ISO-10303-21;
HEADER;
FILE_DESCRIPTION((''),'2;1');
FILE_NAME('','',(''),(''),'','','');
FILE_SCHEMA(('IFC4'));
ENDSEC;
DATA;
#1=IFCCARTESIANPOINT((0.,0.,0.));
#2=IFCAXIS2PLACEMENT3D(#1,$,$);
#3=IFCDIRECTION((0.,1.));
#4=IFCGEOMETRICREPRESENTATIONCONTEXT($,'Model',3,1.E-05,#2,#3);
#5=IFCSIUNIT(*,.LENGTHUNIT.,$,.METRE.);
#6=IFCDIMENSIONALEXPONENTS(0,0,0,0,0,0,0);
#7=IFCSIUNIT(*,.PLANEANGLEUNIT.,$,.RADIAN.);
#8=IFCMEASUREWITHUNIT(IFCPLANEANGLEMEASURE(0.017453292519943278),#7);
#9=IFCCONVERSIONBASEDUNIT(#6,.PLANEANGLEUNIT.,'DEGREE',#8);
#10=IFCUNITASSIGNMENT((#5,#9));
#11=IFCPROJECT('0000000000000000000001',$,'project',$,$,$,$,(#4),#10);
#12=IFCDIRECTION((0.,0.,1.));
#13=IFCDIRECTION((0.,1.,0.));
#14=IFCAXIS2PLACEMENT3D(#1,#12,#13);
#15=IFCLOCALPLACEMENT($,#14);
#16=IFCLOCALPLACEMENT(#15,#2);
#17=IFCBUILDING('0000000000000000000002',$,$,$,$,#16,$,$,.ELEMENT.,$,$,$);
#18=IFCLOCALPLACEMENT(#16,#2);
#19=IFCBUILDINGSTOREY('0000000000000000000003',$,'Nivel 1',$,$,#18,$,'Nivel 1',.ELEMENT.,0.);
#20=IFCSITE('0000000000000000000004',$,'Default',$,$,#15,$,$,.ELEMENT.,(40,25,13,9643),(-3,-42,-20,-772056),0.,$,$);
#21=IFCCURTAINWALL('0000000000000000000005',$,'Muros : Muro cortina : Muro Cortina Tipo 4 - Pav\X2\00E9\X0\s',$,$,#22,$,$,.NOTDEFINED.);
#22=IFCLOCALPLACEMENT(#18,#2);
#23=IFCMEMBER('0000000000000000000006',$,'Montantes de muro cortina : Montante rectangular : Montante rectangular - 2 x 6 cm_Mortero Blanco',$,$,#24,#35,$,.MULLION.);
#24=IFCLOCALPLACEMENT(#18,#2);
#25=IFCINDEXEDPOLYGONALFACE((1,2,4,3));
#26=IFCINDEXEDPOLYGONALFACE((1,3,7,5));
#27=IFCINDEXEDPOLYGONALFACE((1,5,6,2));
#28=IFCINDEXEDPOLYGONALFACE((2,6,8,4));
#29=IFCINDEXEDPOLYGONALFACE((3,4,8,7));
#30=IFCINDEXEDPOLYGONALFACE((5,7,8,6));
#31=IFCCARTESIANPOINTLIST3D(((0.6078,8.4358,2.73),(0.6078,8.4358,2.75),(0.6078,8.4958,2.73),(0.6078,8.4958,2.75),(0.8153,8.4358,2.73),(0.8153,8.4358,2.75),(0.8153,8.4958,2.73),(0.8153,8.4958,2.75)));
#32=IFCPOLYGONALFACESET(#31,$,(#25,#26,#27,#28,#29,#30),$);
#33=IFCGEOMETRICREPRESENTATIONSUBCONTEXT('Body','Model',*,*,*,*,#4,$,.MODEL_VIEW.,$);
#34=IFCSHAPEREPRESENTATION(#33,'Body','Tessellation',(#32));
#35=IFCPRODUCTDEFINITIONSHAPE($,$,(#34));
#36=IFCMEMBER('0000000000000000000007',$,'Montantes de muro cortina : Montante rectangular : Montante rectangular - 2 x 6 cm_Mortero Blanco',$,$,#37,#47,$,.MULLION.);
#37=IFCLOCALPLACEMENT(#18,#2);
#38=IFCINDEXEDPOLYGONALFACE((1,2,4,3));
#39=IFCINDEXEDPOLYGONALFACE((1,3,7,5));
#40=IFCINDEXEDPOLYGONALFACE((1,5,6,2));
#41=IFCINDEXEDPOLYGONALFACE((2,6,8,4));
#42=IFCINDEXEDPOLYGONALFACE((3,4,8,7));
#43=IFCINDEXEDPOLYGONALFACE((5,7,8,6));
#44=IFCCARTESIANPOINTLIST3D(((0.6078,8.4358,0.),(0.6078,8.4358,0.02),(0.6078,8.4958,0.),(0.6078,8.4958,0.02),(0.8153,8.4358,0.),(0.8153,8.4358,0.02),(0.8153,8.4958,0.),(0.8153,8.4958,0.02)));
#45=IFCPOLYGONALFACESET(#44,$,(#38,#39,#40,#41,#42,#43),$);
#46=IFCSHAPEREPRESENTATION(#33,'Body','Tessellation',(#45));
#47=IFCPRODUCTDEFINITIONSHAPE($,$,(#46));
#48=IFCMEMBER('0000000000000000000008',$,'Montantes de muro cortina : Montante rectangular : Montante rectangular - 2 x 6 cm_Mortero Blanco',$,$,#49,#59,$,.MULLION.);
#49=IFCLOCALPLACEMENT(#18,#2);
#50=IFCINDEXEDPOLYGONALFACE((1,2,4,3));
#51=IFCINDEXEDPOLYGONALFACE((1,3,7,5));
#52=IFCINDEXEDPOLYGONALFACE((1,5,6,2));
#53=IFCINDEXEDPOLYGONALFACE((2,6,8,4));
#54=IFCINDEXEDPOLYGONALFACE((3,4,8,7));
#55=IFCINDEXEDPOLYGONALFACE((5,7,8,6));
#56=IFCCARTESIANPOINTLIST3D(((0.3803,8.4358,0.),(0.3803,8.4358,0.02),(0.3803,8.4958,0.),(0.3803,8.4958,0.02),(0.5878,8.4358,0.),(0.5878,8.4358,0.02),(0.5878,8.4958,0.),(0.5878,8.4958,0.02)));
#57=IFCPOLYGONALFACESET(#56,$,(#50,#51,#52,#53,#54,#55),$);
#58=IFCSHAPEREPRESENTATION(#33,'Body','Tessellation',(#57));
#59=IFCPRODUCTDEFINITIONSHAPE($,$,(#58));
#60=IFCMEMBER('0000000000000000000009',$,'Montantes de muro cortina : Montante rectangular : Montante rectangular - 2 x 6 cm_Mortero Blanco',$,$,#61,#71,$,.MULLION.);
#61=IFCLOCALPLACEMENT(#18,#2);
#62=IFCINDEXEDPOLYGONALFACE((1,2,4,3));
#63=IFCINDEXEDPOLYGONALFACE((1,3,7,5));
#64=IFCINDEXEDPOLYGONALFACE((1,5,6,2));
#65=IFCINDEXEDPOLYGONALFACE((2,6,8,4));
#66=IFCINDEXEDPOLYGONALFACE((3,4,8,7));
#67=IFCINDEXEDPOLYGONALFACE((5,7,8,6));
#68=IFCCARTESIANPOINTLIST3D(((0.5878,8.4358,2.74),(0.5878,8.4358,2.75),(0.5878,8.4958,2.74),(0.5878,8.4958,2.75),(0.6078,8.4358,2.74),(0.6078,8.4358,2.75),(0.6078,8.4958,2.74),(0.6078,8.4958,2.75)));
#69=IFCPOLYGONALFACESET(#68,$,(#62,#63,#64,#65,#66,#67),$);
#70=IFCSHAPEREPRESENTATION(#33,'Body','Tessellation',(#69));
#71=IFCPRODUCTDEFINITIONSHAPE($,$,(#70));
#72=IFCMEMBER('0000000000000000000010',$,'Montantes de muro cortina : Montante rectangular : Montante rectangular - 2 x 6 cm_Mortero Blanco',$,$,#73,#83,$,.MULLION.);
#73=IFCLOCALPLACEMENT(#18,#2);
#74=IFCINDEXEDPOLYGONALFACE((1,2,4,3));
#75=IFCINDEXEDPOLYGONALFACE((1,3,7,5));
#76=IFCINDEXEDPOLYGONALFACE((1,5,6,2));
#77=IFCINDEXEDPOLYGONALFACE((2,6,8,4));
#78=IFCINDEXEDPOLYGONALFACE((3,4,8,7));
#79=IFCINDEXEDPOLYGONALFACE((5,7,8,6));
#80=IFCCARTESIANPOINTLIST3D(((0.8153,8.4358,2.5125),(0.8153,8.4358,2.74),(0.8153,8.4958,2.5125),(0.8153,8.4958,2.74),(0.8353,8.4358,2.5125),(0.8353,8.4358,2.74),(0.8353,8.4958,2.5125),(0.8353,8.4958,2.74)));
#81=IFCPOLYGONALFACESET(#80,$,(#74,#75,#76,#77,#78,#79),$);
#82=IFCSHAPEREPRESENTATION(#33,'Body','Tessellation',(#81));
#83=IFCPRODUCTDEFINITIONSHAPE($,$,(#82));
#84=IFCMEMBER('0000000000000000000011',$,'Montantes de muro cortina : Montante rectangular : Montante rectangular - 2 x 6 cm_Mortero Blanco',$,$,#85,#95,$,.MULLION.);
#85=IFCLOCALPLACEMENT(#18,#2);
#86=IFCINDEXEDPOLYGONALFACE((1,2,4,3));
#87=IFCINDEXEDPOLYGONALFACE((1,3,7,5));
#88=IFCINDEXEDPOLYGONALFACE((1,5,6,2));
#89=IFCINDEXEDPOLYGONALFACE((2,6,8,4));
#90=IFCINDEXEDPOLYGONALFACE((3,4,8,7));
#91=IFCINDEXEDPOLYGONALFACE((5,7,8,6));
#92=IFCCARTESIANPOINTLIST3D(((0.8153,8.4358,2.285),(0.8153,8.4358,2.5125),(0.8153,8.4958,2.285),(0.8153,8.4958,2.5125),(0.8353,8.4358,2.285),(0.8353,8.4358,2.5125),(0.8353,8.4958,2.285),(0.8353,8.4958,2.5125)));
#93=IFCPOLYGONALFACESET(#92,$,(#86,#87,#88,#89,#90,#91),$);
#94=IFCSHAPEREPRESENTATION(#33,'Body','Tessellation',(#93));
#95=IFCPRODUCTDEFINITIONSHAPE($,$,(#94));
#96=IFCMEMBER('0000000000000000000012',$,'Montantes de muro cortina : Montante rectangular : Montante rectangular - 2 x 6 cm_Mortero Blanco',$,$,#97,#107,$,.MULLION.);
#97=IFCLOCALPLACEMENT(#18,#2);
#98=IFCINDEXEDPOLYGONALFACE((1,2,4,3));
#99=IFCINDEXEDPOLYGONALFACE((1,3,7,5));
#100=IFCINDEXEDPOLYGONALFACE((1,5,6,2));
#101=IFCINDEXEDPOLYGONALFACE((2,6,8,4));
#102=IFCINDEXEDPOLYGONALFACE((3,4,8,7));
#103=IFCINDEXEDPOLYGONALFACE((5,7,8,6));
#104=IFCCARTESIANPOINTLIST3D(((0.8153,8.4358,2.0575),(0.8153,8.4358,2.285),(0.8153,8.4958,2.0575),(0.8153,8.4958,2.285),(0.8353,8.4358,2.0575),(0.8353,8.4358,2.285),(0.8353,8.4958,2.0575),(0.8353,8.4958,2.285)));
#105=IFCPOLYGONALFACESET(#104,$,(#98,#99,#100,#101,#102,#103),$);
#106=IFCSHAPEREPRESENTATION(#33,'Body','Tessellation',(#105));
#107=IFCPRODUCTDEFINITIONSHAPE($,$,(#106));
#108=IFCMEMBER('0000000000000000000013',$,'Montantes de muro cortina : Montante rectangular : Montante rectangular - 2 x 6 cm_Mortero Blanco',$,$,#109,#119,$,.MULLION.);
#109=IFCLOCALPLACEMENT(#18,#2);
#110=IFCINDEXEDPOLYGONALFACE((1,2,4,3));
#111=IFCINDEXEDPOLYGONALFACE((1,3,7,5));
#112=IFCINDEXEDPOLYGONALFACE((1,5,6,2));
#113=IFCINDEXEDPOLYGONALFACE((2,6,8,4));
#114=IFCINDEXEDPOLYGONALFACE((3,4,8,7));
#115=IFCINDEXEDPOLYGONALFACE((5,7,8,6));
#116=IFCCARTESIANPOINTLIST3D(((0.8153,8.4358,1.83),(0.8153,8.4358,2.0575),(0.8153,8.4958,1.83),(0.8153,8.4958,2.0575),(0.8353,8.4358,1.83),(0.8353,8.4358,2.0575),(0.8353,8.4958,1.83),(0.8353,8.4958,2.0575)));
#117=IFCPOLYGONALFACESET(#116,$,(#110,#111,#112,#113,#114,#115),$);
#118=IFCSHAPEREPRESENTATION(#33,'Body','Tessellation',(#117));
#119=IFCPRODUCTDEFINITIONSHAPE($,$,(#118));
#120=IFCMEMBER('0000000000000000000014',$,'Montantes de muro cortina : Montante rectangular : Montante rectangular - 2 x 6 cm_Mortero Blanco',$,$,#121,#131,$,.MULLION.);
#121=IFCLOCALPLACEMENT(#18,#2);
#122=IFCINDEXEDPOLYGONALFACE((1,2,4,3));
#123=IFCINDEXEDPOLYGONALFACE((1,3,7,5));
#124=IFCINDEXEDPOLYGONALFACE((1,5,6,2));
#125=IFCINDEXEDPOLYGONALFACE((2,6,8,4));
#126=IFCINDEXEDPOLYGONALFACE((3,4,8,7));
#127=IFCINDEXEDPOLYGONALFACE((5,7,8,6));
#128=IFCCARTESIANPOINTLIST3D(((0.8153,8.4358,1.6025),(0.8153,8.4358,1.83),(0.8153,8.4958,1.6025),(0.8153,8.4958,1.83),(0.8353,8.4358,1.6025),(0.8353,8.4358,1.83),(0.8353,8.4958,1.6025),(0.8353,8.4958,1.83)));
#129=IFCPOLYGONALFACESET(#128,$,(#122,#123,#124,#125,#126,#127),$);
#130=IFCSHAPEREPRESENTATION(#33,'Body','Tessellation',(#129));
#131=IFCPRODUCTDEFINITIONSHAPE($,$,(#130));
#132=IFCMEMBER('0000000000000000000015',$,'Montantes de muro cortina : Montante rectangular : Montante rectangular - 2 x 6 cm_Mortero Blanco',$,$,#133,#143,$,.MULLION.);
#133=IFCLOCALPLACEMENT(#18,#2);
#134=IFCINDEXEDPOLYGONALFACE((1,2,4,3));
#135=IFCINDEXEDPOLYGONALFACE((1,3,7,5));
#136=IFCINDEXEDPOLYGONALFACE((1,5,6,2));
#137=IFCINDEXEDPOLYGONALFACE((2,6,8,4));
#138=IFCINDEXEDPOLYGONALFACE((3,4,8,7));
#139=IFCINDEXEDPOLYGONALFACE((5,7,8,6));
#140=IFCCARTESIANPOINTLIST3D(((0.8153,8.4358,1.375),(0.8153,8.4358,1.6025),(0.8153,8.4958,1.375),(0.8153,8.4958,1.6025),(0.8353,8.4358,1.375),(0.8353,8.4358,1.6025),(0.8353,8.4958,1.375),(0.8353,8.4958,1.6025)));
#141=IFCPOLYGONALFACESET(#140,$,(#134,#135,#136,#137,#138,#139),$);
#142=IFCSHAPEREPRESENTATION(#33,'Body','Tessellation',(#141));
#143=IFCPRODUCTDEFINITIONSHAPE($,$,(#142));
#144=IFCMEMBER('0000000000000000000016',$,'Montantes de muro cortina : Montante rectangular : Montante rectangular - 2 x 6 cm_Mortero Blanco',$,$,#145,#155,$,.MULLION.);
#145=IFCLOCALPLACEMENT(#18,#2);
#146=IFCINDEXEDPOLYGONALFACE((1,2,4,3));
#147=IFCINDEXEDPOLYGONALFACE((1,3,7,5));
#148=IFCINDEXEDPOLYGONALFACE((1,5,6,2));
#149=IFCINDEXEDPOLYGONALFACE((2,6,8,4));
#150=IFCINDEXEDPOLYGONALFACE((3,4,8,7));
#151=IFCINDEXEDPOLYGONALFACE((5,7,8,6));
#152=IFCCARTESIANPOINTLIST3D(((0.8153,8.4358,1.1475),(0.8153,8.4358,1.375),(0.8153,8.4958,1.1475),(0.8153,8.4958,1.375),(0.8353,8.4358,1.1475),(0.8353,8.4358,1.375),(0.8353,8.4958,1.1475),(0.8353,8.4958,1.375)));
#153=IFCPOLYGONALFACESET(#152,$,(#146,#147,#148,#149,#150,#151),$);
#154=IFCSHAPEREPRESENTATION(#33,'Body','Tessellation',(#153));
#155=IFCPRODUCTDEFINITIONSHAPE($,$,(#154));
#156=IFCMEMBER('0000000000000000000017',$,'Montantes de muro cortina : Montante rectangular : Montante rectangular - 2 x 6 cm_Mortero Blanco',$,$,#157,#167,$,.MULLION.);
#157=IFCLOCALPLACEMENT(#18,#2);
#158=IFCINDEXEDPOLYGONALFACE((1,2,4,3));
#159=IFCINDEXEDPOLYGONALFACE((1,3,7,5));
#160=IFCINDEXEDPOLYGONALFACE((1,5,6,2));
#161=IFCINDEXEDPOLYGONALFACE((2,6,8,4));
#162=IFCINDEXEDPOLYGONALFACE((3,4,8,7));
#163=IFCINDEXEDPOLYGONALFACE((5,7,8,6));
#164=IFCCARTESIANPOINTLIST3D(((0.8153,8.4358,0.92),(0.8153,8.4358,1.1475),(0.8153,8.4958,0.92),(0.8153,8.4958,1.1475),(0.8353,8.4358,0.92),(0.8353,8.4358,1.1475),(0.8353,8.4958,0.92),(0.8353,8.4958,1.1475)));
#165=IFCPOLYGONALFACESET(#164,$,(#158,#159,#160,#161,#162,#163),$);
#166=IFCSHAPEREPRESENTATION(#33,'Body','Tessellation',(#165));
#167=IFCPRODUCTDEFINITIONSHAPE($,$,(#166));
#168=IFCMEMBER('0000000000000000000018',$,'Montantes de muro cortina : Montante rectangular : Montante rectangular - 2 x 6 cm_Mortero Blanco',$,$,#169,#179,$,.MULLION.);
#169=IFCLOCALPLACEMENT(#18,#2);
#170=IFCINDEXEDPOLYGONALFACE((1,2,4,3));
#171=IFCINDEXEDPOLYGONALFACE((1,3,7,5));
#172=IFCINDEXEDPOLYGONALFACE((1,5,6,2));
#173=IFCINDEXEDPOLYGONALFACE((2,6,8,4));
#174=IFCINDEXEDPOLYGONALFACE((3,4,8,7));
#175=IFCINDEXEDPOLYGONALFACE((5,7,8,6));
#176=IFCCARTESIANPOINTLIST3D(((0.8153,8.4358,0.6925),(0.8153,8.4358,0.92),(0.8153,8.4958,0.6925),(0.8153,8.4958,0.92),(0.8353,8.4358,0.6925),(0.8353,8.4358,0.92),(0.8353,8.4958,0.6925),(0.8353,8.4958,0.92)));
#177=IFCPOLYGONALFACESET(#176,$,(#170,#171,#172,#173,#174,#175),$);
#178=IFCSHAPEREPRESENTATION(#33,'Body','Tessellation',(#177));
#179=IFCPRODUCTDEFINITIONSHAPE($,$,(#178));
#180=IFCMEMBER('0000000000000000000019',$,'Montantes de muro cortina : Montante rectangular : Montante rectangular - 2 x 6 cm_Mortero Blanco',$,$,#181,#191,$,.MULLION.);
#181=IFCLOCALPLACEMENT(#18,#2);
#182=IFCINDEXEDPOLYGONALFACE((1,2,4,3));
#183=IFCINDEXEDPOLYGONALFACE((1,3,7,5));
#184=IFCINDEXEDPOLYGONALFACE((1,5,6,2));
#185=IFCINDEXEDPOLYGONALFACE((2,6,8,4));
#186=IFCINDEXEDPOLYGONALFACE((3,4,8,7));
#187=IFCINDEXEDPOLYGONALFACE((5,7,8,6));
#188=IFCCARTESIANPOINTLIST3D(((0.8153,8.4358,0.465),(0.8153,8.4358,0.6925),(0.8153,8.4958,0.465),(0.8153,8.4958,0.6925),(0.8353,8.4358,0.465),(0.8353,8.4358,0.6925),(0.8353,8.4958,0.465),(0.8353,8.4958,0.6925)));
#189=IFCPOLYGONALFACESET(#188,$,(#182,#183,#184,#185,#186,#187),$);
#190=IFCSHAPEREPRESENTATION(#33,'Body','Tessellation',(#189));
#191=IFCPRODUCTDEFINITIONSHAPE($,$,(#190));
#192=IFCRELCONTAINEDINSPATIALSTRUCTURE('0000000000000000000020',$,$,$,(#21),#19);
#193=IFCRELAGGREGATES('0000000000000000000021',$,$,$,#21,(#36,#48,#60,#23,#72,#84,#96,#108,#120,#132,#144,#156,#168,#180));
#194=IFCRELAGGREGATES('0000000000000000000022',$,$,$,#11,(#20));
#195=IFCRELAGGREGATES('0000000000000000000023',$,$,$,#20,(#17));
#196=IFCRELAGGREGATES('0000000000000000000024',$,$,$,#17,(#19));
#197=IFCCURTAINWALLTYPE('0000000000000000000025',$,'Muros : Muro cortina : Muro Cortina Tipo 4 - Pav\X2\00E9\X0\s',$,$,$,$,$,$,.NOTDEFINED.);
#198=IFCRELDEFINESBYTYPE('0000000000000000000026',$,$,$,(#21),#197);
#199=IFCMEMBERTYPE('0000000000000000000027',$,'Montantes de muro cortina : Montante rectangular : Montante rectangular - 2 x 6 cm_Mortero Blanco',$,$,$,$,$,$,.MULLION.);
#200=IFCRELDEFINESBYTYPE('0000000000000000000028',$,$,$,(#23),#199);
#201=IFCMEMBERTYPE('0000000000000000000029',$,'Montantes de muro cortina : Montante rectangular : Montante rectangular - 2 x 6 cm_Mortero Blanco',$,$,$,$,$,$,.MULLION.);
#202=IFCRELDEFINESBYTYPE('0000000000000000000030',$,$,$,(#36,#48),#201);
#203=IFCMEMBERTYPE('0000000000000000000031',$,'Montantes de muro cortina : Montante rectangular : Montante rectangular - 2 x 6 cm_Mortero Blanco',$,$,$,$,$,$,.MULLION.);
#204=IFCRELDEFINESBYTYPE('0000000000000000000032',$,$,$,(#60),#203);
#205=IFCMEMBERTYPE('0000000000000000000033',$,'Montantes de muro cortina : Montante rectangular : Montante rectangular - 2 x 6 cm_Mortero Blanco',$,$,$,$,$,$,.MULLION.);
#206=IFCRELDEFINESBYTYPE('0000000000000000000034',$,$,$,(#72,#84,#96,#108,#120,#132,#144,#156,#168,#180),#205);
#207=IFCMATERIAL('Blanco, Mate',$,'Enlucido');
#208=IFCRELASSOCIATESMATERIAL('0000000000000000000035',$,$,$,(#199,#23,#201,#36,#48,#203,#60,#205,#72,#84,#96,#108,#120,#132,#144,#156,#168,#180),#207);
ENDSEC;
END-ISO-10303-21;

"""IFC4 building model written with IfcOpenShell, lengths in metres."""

from ifc_helpers import new_model, entity, si_unit, converted_unit, direction, frame, origin, place, context, subcontext, project, spatial, indexed_curve, outline, extrude, source, transform, mapped, material, type_object, type_shapes, element, aggregate, save


model = new_model("IFC4")

# Units and contexts
model_context = context("Model", 3, precision=1e-05, world=origin(), true_north=direction((0.0, 1.0)))
body_context = subcontext(model_context, "Body", "Model", "MODEL_VIEW")
ifc_project = project(units=[si_unit("LENGTHUNIT", "METRE"), converted_unit("PLANEANGLEUNIT", "DEGREE", entity("IfcPlaneAngleMeasure", 0.017453292519943278), si_unit("PLANEANGLEUNIT", "RADIAN"), dimensions=[0, 0, 0, 0, 0, 0, 0])], contexts=[model_context])

# Site, building, storey
site_placement = place(None, frame((0.0, 0.0, 0.0), z_axis=(0.0, 0.0, 1.0), x_axis=(0.0, 1.0, 0.0)))
site = spatial("IfcSite", under=ifc_project, at=site_placement, Name="Default", CompositionType="ELEMENT", RefLatitude=(40, 25, 13, 9643), RefLongitude=(-3, -42, -20, -772056), RefElevation=0.0)
building_placement = place(site_placement, origin())
building = spatial("IfcBuilding", under=site, at=building_placement, CompositionType="ELEMENT")
storey_placement = place(building_placement, origin())
storey = spatial("IfcBuildingStorey", under=building, at=storey_placement, Name="Nivel 1", LongName="Nivel 1", CompositionType="ELEMENT", Elevation=0.0)

# Curtain wall, members
curtain_wall_type_1 = type_object("IfcCurtainWallType", Name="Muros : Muro cortina : Muro Cortina Tipo 4 - Pavés", PredefinedType="NOTDEFINED")
curtain_wall_1_placement = place(storey_placement, origin())
curtain_wall_1 = element("IfcCurtainWall", 1, at=curtain_wall_1_placement, inside=storey, type_object=curtain_wall_type_1, Name="Muros : Muro cortina : Muro Cortina Tipo 4 - Pavés", PredefinedType="NOTDEFINED")
ifc_material_1 = material(Name="Blanco, Mate", Category="Enlucido")
member_type_1 = type_object("IfcMemberType", Name="Montantes de muro cortina : Montante rectangular : Montante rectangular - 2 x 6 cm_Mortero Blanco", PredefinedType="MULLION", material=ifc_material_1)
shared_shape_1 = source(origin(), body_context, "Body", "SweptSolid", [
    extrude(outline(indexed_curve([(-0.01, -0.03), (0.01, -0.03), (0.01, 0.03), (-0.01, 0.03), (-0.01, -0.03)], self_intersect=False)), frame((0.0, 0.0, -0.2075), z_axis=(0.0, 0.0, 1.0), x_axis=(-1.0, 0.0, 0.0)), (0.0, 0.0, 1.0), 0.2075),
])
type_shapes(member_type_1, [shared_shape_1])
member_1_placement = place(curtain_wall_1_placement, frame((0.6078, 8.4658, 2.74), z_axis=(-1.0, 0.0, 0.0), x_axis=(0.0, 0.0, 1.0)))
member_1 = element("IfcMember", 2, at=member_1_placement, type_object=member_type_1, material=ifc_material_1, Name="Montantes de muro cortina : Montante rectangular : Montante rectangular - 2 x 6 cm_Mortero Blanco", PredefinedType="MULLION", context=body_context, shape_type="MappedRepresentation", body=[
    mapped(shared_shape_1, transform((0.0, 0.0, 0.0), scale=1.0)),
])
member_type_2 = type_object("IfcMemberType", Name="Montantes de muro cortina : Montante rectangular : Montante rectangular - 2 x 6 cm_Mortero Blanco", PredefinedType="MULLION", material=ifc_material_1)
shared_shape_2 = source(origin(), body_context, "Body", "SweptSolid", [
    extrude(outline(indexed_curve([(-0.01, -0.03), (0.01, -0.03), (0.01, 0.03), (-0.01, 0.03), (-0.01, -0.03)], self_intersect=False)), frame((-0.01, 0.0, -0.2075), z_axis=(0.0, 0.0, 1.0), x_axis=(-1.0, 0.0, 0.0)), (0.0, 0.0, 1.0), 0.2075),
])
type_shapes(member_type_2, [shared_shape_2])
member_2_placement = place(curtain_wall_1_placement, frame((0.8153, 8.4658, 0.0), z_axis=(1.0, 0.0, 0.0), x_axis=(0.0, 0.0, -1.0)))
member_2 = element("IfcMember", 3, at=member_2_placement, type_object=member_type_2, material=ifc_material_1, Name="Montantes de muro cortina : Montante rectangular : Montante rectangular - 2 x 6 cm_Mortero Blanco", PredefinedType="MULLION", context=body_context, shape_type="MappedRepresentation", body=[
    mapped(shared_shape_2, transform((0.0, 0.0, 0.0), scale=1.0)),
])
member_3_placement = place(curtain_wall_1_placement, frame((0.5878, 8.4658, 0.0), z_axis=(1.0, 0.0, 0.0), x_axis=(0.0, 0.0, -1.0)))
member_3 = element("IfcMember", 4, at=member_3_placement, type_object=member_type_2, material=ifc_material_1, Name="Montantes de muro cortina : Montante rectangular : Montante rectangular - 2 x 6 cm_Mortero Blanco", PredefinedType="MULLION", context=body_context, shape_type="MappedRepresentation", body=[
    mapped(shared_shape_2, transform((0.0, 0.0, 0.0), scale=1.0)),
])
member_type_3 = type_object("IfcMemberType", Name="Montantes de muro cortina : Montante rectangular : Montante rectangular - 2 x 6 cm_Mortero Blanco", PredefinedType="MULLION", material=ifc_material_1)
shared_shape_3 = source(origin(), body_context, "Body", "SweptSolid", [
    extrude(outline(indexed_curve([(-0.01, -0.03), (0.01, -0.03), (0.01, 0.03), (-0.01, 0.03), (-0.01, -0.03)], self_intersect=False)), frame((0.0, 0.0, -0.01), z_axis=(0.0, 0.0, 1.0), x_axis=(-1.0, 0.0, 0.0)), (0.0, 0.0, 1.0), 0.01),
])
type_shapes(member_type_3, [shared_shape_3])
member_4_placement = place(curtain_wall_1_placement, frame((0.5978, 8.4658, 2.74), z_axis=(0.0, 0.0, -1.0), x_axis=(-1.0, 0.0, 0.0)))
member_4 = element("IfcMember", 5, at=member_4_placement, type_object=member_type_3, material=ifc_material_1, Name="Montantes de muro cortina : Montante rectangular : Montante rectangular - 2 x 6 cm_Mortero Blanco", PredefinedType="MULLION", context=body_context, shape_type="MappedRepresentation", body=[
    mapped(shared_shape_3, transform((0.0, 0.0, 0.0), scale=1.0)),
])
member_type_4 = type_object("IfcMemberType", Name="Montantes de muro cortina : Montante rectangular : Montante rectangular - 2 x 6 cm_Mortero Blanco", PredefinedType="MULLION", material=ifc_material_1)
shared_shape_4 = source(origin(), body_context, "Body", "SweptSolid", [
    extrude(outline(indexed_curve([(-0.01, -0.03), (0.01, -0.03), (0.01, 0.03), (-0.01, 0.03), (-0.01, -0.03)], self_intersect=False)), frame((-0.01, 0.0, -0.2275), z_axis=(0.0, 0.0, 1.0), x_axis=(-1.0, 0.0, 0.0)), (0.0, 0.0, 1.0), 0.2275),
])
type_shapes(member_type_4, [shared_shape_4])
member_5_placement = place(curtain_wall_1_placement, frame((0.8353, 8.4658, 2.74)))
member_5 = element("IfcMember", 6, at=member_5_placement, type_object=member_type_4, material=ifc_material_1, Name="Montantes de muro cortina : Montante rectangular : Montante rectangular - 2 x 6 cm_Mortero Blanco", PredefinedType="MULLION", context=body_context, shape_type="MappedRepresentation", body=[
    mapped(shared_shape_4, transform((0.0, 0.0, 0.0), scale=1.0)),
])
member_6_placement = place(curtain_wall_1_placement, frame((0.8353, 8.4658, 2.5125)))
member_6 = element("IfcMember", 7, at=member_6_placement, type_object=member_type_4, material=ifc_material_1, Name="Montantes de muro cortina : Montante rectangular : Montante rectangular - 2 x 6 cm_Mortero Blanco", PredefinedType="MULLION", context=body_context, shape_type="MappedRepresentation", body=[
    mapped(shared_shape_4, transform((0.0, 0.0, 0.0), scale=1.0)),
])
member_7_placement = place(curtain_wall_1_placement, frame((0.8353, 8.4658, 2.285)))
member_7 = element("IfcMember", 8, at=member_7_placement, type_object=member_type_4, material=ifc_material_1, Name="Montantes de muro cortina : Montante rectangular : Montante rectangular - 2 x 6 cm_Mortero Blanco", PredefinedType="MULLION", context=body_context, shape_type="MappedRepresentation", body=[
    mapped(shared_shape_4, transform((0.0, 0.0, 0.0), scale=1.0)),
])
member_8_placement = place(curtain_wall_1_placement, frame((0.8353, 8.4658, 2.0575)))
member_8 = element("IfcMember", 9, at=member_8_placement, type_object=member_type_4, material=ifc_material_1, Name="Montantes de muro cortina : Montante rectangular : Montante rectangular - 2 x 6 cm_Mortero Blanco", PredefinedType="MULLION", context=body_context, shape_type="MappedRepresentation", body=[
    mapped(shared_shape_4, transform((0.0, 0.0, 0.0), scale=1.0)),
])
member_9_placement = place(curtain_wall_1_placement, frame((0.8353, 8.4658, 1.83)))
member_9 = element("IfcMember", 10, at=member_9_placement, type_object=member_type_4, material=ifc_material_1, Name="Montantes de muro cortina : Montante rectangular : Montante rectangular - 2 x 6 cm_Mortero Blanco", PredefinedType="MULLION", context=body_context, shape_type="MappedRepresentation", body=[
    mapped(shared_shape_4, transform((0.0, 0.0, 0.0), scale=1.0)),
])
member_10_placement = place(curtain_wall_1_placement, frame((0.8353, 8.4658, 1.6025)))
member_10 = element("IfcMember", 11, at=member_10_placement, type_object=member_type_4, material=ifc_material_1, Name="Montantes de muro cortina : Montante rectangular : Montante rectangular - 2 x 6 cm_Mortero Blanco", PredefinedType="MULLION", context=body_context, shape_type="MappedRepresentation", body=[
    mapped(shared_shape_4, transform((0.0, 0.0, 0.0), scale=1.0)),
])
member_11_placement = place(curtain_wall_1_placement, frame((0.8353, 8.4658, 1.375)))
member_11 = element("IfcMember", 12, at=member_11_placement, type_object=member_type_4, material=ifc_material_1, Name="Montantes de muro cortina : Montante rectangular : Montante rectangular - 2 x 6 cm_Mortero Blanco", PredefinedType="MULLION", context=body_context, shape_type="MappedRepresentation", body=[
    mapped(shared_shape_4, transform((0.0, 0.0, 0.0), scale=1.0)),
])
member_12_placement = place(curtain_wall_1_placement, frame((0.8353, 8.4658, 1.1475)))
member_12 = element("IfcMember", 13, at=member_12_placement, type_object=member_type_4, material=ifc_material_1, Name="Montantes de muro cortina : Montante rectangular : Montante rectangular - 2 x 6 cm_Mortero Blanco", PredefinedType="MULLION", context=body_context, shape_type="MappedRepresentation", body=[
    mapped(shared_shape_4, transform((0.0, 0.0, 0.0), scale=1.0)),
])
member_13_placement = place(curtain_wall_1_placement, frame((0.8353, 8.4658, 0.92)))
member_13 = element("IfcMember", 14, at=member_13_placement, type_object=member_type_4, material=ifc_material_1, Name="Montantes de muro cortina : Montante rectangular : Montante rectangular - 2 x 6 cm_Mortero Blanco", PredefinedType="MULLION", context=body_context, shape_type="MappedRepresentation", body=[
    mapped(shared_shape_4, transform((0.0, 0.0, 0.0), scale=1.0)),
])
member_14_placement = place(curtain_wall_1_placement, frame((0.8353, 8.4658, 0.6925)))
member_14 = element("IfcMember", 15, at=member_14_placement, type_object=member_type_4, material=ifc_material_1, Name="Montantes de muro cortina : Montante rectangular : Montante rectangular - 2 x 6 cm_Mortero Blanco", PredefinedType="MULLION", context=body_context, shape_type="MappedRepresentation", body=[
    mapped(shared_shape_4, transform((0.0, 0.0, 0.0), scale=1.0)),
])
aggregate(curtain_wall_1, [member_2, member_3, member_4, member_1, member_5, member_6, member_7, member_8, member_9, member_10, member_11, member_12, member_13, member_14])

save(model, "model.ifc")
